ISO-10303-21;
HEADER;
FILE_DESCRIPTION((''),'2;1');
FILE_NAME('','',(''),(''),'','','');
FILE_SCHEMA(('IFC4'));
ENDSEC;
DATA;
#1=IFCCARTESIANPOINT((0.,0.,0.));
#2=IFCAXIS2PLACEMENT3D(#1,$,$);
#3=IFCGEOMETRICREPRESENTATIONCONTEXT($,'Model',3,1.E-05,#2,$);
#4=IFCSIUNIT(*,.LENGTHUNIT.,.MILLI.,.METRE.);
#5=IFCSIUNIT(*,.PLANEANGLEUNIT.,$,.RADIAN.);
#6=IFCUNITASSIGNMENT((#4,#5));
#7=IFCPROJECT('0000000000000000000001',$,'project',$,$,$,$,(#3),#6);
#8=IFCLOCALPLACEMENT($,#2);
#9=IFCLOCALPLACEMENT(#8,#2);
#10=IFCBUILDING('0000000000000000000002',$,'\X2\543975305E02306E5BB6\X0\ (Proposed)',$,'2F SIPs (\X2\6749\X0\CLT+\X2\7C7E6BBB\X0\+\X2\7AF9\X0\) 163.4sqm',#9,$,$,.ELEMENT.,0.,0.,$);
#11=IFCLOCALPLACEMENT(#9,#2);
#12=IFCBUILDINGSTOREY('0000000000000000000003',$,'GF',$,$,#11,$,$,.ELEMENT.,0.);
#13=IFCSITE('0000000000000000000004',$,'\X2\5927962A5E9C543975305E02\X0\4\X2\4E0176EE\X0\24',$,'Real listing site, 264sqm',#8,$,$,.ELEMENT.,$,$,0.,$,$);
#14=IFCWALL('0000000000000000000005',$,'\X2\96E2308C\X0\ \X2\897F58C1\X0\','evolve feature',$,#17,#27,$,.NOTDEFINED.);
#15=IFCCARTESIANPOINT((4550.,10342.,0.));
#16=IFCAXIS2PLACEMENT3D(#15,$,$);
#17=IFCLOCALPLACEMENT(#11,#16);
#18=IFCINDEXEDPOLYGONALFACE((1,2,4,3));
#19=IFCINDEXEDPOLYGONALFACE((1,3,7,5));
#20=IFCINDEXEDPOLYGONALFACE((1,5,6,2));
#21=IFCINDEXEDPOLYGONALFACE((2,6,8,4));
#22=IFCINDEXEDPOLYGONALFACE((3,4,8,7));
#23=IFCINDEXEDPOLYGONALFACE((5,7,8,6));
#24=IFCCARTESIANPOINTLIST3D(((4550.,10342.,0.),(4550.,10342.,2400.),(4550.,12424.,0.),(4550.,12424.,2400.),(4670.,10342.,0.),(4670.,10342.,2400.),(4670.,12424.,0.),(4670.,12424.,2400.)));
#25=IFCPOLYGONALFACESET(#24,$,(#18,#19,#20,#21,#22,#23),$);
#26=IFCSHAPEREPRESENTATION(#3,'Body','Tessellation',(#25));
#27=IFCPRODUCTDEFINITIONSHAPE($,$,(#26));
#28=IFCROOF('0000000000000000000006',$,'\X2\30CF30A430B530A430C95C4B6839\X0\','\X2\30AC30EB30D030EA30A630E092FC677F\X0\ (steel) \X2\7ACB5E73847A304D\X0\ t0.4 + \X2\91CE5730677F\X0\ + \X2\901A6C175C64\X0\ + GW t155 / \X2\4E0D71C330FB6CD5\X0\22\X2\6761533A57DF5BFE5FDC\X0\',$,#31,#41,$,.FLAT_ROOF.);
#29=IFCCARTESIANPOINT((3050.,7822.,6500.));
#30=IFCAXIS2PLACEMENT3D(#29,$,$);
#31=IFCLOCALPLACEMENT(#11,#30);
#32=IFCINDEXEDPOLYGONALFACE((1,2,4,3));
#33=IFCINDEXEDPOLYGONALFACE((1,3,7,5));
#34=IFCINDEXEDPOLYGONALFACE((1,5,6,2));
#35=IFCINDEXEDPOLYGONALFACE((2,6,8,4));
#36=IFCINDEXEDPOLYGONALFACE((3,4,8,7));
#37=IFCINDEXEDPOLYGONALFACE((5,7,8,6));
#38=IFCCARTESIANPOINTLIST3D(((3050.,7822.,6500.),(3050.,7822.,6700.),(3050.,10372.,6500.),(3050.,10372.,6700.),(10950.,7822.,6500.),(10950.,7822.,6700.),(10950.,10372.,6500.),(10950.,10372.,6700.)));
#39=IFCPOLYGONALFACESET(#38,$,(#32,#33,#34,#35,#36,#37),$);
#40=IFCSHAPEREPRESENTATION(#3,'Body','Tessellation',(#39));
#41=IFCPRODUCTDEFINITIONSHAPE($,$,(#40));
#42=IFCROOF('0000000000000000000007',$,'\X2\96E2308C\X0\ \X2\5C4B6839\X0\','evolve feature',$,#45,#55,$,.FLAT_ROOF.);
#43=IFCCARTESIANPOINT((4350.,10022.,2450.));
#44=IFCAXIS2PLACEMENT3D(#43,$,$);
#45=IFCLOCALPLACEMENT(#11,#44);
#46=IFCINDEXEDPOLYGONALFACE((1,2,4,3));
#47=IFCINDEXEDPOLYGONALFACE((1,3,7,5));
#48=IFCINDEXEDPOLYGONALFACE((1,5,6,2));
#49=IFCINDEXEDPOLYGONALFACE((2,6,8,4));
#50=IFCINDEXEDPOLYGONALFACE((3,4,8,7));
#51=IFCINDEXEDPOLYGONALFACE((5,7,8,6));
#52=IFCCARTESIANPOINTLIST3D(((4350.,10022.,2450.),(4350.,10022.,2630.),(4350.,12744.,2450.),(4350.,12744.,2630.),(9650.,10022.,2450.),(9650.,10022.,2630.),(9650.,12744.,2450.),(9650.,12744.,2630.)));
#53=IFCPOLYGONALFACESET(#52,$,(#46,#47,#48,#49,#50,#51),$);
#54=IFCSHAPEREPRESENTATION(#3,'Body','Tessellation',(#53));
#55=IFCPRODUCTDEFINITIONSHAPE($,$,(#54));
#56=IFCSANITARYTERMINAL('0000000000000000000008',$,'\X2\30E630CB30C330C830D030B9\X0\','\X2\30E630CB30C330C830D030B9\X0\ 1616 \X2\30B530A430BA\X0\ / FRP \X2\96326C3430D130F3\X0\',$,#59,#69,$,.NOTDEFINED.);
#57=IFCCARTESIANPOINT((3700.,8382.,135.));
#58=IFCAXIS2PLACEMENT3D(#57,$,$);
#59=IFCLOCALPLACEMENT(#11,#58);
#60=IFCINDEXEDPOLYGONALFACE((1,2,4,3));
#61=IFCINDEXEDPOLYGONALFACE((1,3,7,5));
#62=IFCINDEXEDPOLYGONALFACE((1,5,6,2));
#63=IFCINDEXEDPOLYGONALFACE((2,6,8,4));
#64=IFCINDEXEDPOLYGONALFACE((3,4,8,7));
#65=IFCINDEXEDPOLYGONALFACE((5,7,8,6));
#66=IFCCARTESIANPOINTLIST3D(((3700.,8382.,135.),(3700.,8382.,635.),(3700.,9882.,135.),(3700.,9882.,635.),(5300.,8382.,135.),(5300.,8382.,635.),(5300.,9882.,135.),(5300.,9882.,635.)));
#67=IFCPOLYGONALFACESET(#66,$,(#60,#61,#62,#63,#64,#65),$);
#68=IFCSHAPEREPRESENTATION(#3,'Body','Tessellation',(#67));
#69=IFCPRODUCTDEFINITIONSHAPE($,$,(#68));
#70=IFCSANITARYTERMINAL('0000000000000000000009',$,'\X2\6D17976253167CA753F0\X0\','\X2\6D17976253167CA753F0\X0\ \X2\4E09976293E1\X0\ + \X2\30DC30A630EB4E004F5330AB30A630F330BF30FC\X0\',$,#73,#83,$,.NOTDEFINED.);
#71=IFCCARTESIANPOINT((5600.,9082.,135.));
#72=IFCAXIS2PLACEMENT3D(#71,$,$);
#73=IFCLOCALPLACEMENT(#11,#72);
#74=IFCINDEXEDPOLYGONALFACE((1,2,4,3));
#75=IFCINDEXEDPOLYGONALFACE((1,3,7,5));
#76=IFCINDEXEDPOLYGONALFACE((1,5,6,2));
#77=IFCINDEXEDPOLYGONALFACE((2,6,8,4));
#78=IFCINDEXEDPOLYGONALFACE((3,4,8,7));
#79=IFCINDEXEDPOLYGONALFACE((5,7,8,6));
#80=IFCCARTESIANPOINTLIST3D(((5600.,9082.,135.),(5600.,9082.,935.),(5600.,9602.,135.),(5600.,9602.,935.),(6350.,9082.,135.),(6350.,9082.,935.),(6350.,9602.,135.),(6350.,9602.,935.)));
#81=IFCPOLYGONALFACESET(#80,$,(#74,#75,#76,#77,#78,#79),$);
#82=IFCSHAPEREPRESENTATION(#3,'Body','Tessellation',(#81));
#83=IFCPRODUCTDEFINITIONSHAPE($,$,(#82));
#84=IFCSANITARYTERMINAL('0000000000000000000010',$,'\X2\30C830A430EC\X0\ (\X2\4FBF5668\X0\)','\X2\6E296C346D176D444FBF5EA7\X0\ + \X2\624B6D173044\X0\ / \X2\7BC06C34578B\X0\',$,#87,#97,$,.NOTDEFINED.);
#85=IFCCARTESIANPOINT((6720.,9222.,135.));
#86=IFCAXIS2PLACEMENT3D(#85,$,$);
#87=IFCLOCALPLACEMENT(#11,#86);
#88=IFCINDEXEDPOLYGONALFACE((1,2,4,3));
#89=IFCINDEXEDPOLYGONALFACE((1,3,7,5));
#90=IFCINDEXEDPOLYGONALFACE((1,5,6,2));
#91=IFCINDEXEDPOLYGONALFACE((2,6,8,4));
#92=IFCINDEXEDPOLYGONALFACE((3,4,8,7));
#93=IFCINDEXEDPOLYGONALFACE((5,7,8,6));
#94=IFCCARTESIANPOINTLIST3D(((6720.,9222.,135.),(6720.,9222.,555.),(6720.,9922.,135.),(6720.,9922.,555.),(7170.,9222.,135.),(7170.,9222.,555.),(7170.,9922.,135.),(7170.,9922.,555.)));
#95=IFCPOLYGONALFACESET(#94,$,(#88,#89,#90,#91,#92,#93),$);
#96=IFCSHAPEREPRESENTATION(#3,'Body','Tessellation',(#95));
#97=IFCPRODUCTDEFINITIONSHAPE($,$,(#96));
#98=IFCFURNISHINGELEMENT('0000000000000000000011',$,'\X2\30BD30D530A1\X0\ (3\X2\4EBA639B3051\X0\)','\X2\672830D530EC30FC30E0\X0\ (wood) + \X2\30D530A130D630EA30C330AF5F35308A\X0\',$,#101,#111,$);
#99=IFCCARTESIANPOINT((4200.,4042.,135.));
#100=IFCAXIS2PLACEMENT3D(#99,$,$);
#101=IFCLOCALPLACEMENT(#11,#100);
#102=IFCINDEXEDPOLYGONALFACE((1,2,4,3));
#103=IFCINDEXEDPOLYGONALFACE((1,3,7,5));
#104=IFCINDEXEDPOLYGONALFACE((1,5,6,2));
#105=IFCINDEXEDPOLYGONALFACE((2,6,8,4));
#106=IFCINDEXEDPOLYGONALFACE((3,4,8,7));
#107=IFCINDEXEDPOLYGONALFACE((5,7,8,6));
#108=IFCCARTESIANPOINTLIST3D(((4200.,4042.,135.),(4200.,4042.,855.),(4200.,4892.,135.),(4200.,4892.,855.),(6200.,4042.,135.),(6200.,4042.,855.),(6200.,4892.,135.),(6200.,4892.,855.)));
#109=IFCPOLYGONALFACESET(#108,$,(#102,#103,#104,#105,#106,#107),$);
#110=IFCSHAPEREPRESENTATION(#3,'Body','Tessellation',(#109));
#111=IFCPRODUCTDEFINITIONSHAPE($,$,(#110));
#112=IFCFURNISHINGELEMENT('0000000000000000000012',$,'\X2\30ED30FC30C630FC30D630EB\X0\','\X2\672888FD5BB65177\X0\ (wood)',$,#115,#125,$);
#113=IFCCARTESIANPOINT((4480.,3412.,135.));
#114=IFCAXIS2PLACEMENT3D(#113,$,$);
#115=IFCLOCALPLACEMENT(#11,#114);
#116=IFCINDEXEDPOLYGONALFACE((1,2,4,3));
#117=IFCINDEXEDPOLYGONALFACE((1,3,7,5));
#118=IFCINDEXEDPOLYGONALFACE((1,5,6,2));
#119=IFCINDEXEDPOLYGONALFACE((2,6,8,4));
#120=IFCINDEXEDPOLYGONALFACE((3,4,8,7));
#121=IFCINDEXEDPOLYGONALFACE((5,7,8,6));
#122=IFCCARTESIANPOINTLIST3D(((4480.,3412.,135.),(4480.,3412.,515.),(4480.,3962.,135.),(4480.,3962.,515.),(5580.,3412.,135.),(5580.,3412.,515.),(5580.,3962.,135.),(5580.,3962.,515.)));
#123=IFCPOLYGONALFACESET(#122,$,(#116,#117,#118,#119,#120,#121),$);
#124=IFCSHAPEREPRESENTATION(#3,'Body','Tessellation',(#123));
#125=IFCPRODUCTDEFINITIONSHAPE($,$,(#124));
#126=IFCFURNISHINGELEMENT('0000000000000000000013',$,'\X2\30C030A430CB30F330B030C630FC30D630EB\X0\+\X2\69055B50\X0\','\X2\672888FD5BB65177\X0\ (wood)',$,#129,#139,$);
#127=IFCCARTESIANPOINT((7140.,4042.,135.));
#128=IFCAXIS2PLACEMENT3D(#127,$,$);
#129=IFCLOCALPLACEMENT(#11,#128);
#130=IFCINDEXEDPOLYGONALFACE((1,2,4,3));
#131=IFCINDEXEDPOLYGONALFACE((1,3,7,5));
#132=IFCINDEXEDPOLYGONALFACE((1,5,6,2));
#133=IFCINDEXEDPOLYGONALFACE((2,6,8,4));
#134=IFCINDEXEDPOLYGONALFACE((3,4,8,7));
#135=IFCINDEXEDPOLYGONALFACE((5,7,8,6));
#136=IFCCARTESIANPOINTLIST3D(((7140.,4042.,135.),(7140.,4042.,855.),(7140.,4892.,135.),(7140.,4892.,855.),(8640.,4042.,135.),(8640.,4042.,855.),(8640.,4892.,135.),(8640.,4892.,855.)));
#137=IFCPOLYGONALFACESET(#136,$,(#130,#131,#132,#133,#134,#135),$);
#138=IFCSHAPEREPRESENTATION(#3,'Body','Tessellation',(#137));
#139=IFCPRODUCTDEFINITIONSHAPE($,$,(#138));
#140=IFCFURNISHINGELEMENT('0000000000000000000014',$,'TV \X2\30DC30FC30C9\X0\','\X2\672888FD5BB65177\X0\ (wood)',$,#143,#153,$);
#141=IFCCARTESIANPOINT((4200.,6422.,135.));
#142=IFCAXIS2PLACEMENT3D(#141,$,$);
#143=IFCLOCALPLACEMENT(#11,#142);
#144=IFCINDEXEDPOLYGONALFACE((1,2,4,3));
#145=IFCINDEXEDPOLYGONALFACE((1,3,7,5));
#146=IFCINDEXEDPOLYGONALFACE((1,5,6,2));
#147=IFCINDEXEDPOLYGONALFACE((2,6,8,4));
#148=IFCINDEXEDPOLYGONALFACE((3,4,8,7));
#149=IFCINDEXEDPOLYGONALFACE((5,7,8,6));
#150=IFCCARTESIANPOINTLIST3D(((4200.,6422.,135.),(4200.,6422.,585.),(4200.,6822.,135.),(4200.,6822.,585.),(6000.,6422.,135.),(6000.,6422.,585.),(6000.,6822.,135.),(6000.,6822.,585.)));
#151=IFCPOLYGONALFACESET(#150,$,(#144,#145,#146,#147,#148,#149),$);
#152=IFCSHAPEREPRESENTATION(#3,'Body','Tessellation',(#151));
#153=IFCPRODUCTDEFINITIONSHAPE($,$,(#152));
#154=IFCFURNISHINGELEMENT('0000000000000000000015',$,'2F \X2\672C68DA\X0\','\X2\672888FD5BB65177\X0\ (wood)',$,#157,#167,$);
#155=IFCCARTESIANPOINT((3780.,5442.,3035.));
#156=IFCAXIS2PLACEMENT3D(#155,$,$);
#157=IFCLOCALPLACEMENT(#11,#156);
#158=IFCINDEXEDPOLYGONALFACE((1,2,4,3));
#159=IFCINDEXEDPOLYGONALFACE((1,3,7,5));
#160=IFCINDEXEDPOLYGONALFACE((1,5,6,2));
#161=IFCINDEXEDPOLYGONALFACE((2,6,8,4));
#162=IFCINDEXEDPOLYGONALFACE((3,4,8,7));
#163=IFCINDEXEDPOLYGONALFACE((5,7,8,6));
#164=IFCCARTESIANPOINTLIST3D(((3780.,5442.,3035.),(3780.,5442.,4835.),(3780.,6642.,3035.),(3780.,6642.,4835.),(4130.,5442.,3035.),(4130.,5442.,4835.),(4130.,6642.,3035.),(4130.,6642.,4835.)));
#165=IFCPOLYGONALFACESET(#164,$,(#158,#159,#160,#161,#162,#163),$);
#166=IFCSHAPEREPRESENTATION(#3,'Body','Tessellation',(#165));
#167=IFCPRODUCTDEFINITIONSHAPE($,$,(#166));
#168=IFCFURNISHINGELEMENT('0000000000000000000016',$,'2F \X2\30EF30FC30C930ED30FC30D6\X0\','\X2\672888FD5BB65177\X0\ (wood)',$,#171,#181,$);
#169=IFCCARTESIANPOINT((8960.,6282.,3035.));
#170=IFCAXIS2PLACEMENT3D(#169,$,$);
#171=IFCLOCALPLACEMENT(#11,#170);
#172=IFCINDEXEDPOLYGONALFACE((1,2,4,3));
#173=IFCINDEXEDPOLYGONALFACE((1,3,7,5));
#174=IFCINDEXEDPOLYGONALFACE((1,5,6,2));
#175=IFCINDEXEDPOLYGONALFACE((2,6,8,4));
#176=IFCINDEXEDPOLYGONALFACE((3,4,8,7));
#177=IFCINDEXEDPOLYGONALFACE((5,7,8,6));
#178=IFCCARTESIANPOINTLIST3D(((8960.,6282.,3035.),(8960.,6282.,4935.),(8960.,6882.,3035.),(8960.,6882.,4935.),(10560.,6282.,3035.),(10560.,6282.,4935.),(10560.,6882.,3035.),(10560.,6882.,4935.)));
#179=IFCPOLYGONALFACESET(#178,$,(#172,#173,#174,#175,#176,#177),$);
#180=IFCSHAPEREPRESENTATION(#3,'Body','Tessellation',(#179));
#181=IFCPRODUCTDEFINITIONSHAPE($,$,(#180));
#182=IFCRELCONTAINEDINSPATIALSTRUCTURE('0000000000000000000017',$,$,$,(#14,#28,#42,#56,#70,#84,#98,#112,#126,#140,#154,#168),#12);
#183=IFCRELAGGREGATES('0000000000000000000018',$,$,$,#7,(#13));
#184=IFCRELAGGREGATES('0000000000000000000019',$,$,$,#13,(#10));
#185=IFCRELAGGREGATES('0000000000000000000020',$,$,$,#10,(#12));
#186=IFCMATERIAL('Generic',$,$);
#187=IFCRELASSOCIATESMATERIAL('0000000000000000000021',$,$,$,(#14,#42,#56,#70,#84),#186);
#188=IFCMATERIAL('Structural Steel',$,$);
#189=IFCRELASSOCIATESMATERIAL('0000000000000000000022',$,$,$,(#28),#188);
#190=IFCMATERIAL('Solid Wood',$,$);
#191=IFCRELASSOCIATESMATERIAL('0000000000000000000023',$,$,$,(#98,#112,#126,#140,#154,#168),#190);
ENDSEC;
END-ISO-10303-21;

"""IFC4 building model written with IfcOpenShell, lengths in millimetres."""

from ifc_helpers import new_model, si_unit, frame, frame_2d, origin, place, context, project, spatial, rectangle, extrude, material, element, save


model = new_model("IFC4")

# Units and contexts
model_context = context("Model", 3, precision=1e-05, world=origin())
ifc_project = project(units=[si_unit("LENGTHUNIT", "METRE", prefix="MILLI"), si_unit("PLANEANGLEUNIT", "RADIAN")], contexts=[model_context])

# Site, building, storey
site_placement = place(None, origin())
site = spatial("IfcSite", under=ifc_project, at=site_placement, Name="大阪府吹田市4丁目24", ObjectType="Real listing site, 264sqm", CompositionType="ELEMENT", RefElevation=0.0)
building_placement = place(site_placement, origin())
building = spatial("IfcBuilding", under=site, at=building_placement, Name="吹田市の家 (Proposed)", ObjectType="2F SIPs (杉CLT+籾殻+竹) 163.4sqm", CompositionType="ELEMENT", ElevationOfRefHeight=0.0, ElevationOfTerrain=0.0)
storey_placement = place(building_placement, origin())
storey = spatial("IfcBuildingStorey", under=building, at=storey_placement, Name="GF", CompositionType="ELEMENT", Elevation=0.0)

# Shared definitions
ifc_material_1 = material(Name="Generic")

# Shared definitions
ifc_material_2 = material(Name="Solid Wood")

# Wall
wall_1_placement = place(storey_placement, frame((4550.0, 10342.0, 0.0)))
element("IfcWall", 1, at=wall_1_placement, inside=storey, material=ifc_material_1, Name="離れ 西壁", Description="evolve feature", PredefinedType="NOTDEFINED", context=model_context, shape_type="SweptSolid", body=[
    extrude(rectangle(XDim=120.0, YDim=2082.0, at=frame_2d((60.0, 1041.0))), frame((4550.0, 10342.0, 0.0)), (0.0, 0.0, 1.0), 2400.0),
])

# Roofs
ifc_material_3 = material(Name="Structural Steel")
roof_1_placement = place(storey_placement, frame((3050.0, 7822.0, 6500.0)))
element("IfcRoof", 2, at=roof_1_placement, inside=storey, material=ifc_material_3, Name="ハイサイド屋根", Description="ガルバリウム鋼板 (steel) 立平葺き t0.4 + 野地板 + 通気層 + GW t155 / 不燃・法22条区域対応", PredefinedType="FLAT_ROOF", context=model_context, shape_type="SweptSolid", body=[
    extrude(rectangle(XDim=7900.0, YDim=2550.0, at=frame_2d((3950.0, 1275.0))), frame((3050.0, 7822.0, 6500.0)), (0.0, 0.0, 1.0), 200.0),
])
roof_2_placement = place(storey_placement, frame((4350.0, 10022.0, 2450.0)))
element("IfcRoof", 3, at=roof_2_placement, inside=storey, material=ifc_material_1, Name="離れ 屋根", Description="evolve feature", PredefinedType="FLAT_ROOF", context=model_context, shape_type="SweptSolid", body=[
    extrude(rectangle(XDim=5300.0, YDim=2722.0, at=frame_2d((2650.0, 1361.0))), frame((4350.0, 10022.0, 2450.0)), (0.0, 0.0, 1.0), 180.0),
])

# Sanitary terminals
sanitary_terminal_1_placement = place(storey_placement, frame((3700.0, 8382.0, 135.0)))
element("IfcSanitaryTerminal", 4, at=sanitary_terminal_1_placement, inside=storey, material=ifc_material_1, Name="ユニットバス", Description="ユニットバス 1616 サイズ / FRP 防水パン", PredefinedType="NOTDEFINED", context=model_context, shape_type="SweptSolid", body=[
    extrude(rectangle(XDim=1600.0, YDim=1500.0, at=frame_2d((800.0, 750.0))), frame((3700.0, 8382.0, 135.0)), (0.0, 0.0, 1.0), 500.0),
])
sanitary_terminal_2_placement = place(storey_placement, frame((5600.0, 9082.0, 135.0)))
element("IfcSanitaryTerminal", 5, at=sanitary_terminal_2_placement, inside=storey, material=ifc_material_1, Name="洗面化粧台", Description="洗面化粧台 三面鏡 + ボウル一体カウンター", PredefinedType="NOTDEFINED", context=model_context, shape_type="SweptSolid", body=[
    extrude(rectangle(XDim=750.0, YDim=520.0, at=frame_2d((375.0, 260.0))), frame((5600.0, 9082.0, 135.0)), (0.0, 0.0, 1.0), 800.0),
])
sanitary_terminal_3_placement = place(storey_placement, frame((6720.0, 9222.0, 135.0)))
element("IfcSanitaryTerminal", 6, at=sanitary_terminal_3_placement, inside=storey, material=ifc_material_1, Name="トイレ (便器)", Description="温水洗浄便座 + 手洗い / 節水型", PredefinedType="NOTDEFINED", context=model_context, shape_type="SweptSolid", body=[
    extrude(rectangle(XDim=450.0, YDim=700.0, at=frame_2d((225.0, 350.0))), frame((6720.0, 9222.0, 135.0)), (0.0, 0.0, 1.0), 420.0),
])

# Furnishing elements
furnishing_1_placement = place(storey_placement, frame((4200.0, 4042.0, 135.0)))
element("IfcFurnishingElement", 7, at=furnishing_1_placement, inside=storey, material=ifc_material_2, Name="ソファ (3人掛け)", Description="木フレーム (wood) + ファブリック張り", context=model_context, shape_type="SweptSolid", body=[
    extrude(rectangle(XDim=2000.0, YDim=850.0, at=frame_2d((1000.0, 425.0))), frame((4200.0, 4042.0, 135.0)), (0.0, 0.0, 1.0), 720.0),
])
furnishing_2_placement = place(storey_placement, frame((4480.0, 3412.0, 135.0)))
element("IfcFurnishingElement", 8, at=furnishing_2_placement, inside=storey, material=ifc_material_2, Name="ローテーブル", Description="木製家具 (wood)", context=model_context, shape_type="SweptSolid", body=[
    extrude(rectangle(XDim=1100.0, YDim=550.0, at=frame_2d((550.0, 275.0))), frame((4480.0, 3412.0, 135.0)), (0.0, 0.0, 1.0), 380.0),
])
furnishing_3_placement = place(storey_placement, frame((7140.0, 4042.0, 135.0)))
element("IfcFurnishingElement", 9, at=furnishing_3_placement, inside=storey, material=ifc_material_2, Name="ダイニングテーブル+椅子", Description="木製家具 (wood)", context=model_context, shape_type="SweptSolid", body=[
    extrude(rectangle(XDim=1500.0, YDim=850.0, at=frame_2d((750.0, 425.0))), frame((7140.0, 4042.0, 135.0)), (0.0, 0.0, 1.0), 720.0),
])
furnishing_4_placement = place(storey_placement, frame((4200.0, 6422.0, 135.0)))
element("IfcFurnishingElement", 10, at=furnishing_4_placement, inside=storey, material=ifc_material_2, Name="TV ボード", Description="木製家具 (wood)", context=model_context, shape_type="SweptSolid", body=[
    extrude(rectangle(XDim=1800.0, YDim=400.0, at=frame_2d((900.0, 200.0))), frame((4200.0, 6422.0, 135.0)), (0.0, 0.0, 1.0), 450.0),
])
furnishing_5_placement = place(storey_placement, frame((3780.0, 5442.0, 3035.0)))
element("IfcFurnishingElement", 11, at=furnishing_5_placement, inside=storey, material=ifc_material_2, Name="2F 本棚", Description="木製家具 (wood)", context=model_context, shape_type="SweptSolid", body=[
    extrude(rectangle(XDim=350.0, YDim=1200.0, at=frame_2d((175.0, 600.0))), frame((3780.0, 5442.0, 3035.0)), (0.0, 0.0, 1.0), 1800.0),
])
furnishing_6_placement = place(storey_placement, frame((8960.0, 6282.0, 3035.0)))
element("IfcFurnishingElement", 12, at=furnishing_6_placement, inside=storey, material=ifc_material_2, Name="2F ワードローブ", Description="木製家具 (wood)", context=model_context, shape_type="SweptSolid", body=[
    extrude(rectangle(XDim=1600.0, YDim=600.0, at=frame_2d((800.0, 300.0))), frame((8960.0, 6282.0, 3035.0)), (0.0, 0.0, 1.0), 1900.0),
])

save(model, "model.ifc")
